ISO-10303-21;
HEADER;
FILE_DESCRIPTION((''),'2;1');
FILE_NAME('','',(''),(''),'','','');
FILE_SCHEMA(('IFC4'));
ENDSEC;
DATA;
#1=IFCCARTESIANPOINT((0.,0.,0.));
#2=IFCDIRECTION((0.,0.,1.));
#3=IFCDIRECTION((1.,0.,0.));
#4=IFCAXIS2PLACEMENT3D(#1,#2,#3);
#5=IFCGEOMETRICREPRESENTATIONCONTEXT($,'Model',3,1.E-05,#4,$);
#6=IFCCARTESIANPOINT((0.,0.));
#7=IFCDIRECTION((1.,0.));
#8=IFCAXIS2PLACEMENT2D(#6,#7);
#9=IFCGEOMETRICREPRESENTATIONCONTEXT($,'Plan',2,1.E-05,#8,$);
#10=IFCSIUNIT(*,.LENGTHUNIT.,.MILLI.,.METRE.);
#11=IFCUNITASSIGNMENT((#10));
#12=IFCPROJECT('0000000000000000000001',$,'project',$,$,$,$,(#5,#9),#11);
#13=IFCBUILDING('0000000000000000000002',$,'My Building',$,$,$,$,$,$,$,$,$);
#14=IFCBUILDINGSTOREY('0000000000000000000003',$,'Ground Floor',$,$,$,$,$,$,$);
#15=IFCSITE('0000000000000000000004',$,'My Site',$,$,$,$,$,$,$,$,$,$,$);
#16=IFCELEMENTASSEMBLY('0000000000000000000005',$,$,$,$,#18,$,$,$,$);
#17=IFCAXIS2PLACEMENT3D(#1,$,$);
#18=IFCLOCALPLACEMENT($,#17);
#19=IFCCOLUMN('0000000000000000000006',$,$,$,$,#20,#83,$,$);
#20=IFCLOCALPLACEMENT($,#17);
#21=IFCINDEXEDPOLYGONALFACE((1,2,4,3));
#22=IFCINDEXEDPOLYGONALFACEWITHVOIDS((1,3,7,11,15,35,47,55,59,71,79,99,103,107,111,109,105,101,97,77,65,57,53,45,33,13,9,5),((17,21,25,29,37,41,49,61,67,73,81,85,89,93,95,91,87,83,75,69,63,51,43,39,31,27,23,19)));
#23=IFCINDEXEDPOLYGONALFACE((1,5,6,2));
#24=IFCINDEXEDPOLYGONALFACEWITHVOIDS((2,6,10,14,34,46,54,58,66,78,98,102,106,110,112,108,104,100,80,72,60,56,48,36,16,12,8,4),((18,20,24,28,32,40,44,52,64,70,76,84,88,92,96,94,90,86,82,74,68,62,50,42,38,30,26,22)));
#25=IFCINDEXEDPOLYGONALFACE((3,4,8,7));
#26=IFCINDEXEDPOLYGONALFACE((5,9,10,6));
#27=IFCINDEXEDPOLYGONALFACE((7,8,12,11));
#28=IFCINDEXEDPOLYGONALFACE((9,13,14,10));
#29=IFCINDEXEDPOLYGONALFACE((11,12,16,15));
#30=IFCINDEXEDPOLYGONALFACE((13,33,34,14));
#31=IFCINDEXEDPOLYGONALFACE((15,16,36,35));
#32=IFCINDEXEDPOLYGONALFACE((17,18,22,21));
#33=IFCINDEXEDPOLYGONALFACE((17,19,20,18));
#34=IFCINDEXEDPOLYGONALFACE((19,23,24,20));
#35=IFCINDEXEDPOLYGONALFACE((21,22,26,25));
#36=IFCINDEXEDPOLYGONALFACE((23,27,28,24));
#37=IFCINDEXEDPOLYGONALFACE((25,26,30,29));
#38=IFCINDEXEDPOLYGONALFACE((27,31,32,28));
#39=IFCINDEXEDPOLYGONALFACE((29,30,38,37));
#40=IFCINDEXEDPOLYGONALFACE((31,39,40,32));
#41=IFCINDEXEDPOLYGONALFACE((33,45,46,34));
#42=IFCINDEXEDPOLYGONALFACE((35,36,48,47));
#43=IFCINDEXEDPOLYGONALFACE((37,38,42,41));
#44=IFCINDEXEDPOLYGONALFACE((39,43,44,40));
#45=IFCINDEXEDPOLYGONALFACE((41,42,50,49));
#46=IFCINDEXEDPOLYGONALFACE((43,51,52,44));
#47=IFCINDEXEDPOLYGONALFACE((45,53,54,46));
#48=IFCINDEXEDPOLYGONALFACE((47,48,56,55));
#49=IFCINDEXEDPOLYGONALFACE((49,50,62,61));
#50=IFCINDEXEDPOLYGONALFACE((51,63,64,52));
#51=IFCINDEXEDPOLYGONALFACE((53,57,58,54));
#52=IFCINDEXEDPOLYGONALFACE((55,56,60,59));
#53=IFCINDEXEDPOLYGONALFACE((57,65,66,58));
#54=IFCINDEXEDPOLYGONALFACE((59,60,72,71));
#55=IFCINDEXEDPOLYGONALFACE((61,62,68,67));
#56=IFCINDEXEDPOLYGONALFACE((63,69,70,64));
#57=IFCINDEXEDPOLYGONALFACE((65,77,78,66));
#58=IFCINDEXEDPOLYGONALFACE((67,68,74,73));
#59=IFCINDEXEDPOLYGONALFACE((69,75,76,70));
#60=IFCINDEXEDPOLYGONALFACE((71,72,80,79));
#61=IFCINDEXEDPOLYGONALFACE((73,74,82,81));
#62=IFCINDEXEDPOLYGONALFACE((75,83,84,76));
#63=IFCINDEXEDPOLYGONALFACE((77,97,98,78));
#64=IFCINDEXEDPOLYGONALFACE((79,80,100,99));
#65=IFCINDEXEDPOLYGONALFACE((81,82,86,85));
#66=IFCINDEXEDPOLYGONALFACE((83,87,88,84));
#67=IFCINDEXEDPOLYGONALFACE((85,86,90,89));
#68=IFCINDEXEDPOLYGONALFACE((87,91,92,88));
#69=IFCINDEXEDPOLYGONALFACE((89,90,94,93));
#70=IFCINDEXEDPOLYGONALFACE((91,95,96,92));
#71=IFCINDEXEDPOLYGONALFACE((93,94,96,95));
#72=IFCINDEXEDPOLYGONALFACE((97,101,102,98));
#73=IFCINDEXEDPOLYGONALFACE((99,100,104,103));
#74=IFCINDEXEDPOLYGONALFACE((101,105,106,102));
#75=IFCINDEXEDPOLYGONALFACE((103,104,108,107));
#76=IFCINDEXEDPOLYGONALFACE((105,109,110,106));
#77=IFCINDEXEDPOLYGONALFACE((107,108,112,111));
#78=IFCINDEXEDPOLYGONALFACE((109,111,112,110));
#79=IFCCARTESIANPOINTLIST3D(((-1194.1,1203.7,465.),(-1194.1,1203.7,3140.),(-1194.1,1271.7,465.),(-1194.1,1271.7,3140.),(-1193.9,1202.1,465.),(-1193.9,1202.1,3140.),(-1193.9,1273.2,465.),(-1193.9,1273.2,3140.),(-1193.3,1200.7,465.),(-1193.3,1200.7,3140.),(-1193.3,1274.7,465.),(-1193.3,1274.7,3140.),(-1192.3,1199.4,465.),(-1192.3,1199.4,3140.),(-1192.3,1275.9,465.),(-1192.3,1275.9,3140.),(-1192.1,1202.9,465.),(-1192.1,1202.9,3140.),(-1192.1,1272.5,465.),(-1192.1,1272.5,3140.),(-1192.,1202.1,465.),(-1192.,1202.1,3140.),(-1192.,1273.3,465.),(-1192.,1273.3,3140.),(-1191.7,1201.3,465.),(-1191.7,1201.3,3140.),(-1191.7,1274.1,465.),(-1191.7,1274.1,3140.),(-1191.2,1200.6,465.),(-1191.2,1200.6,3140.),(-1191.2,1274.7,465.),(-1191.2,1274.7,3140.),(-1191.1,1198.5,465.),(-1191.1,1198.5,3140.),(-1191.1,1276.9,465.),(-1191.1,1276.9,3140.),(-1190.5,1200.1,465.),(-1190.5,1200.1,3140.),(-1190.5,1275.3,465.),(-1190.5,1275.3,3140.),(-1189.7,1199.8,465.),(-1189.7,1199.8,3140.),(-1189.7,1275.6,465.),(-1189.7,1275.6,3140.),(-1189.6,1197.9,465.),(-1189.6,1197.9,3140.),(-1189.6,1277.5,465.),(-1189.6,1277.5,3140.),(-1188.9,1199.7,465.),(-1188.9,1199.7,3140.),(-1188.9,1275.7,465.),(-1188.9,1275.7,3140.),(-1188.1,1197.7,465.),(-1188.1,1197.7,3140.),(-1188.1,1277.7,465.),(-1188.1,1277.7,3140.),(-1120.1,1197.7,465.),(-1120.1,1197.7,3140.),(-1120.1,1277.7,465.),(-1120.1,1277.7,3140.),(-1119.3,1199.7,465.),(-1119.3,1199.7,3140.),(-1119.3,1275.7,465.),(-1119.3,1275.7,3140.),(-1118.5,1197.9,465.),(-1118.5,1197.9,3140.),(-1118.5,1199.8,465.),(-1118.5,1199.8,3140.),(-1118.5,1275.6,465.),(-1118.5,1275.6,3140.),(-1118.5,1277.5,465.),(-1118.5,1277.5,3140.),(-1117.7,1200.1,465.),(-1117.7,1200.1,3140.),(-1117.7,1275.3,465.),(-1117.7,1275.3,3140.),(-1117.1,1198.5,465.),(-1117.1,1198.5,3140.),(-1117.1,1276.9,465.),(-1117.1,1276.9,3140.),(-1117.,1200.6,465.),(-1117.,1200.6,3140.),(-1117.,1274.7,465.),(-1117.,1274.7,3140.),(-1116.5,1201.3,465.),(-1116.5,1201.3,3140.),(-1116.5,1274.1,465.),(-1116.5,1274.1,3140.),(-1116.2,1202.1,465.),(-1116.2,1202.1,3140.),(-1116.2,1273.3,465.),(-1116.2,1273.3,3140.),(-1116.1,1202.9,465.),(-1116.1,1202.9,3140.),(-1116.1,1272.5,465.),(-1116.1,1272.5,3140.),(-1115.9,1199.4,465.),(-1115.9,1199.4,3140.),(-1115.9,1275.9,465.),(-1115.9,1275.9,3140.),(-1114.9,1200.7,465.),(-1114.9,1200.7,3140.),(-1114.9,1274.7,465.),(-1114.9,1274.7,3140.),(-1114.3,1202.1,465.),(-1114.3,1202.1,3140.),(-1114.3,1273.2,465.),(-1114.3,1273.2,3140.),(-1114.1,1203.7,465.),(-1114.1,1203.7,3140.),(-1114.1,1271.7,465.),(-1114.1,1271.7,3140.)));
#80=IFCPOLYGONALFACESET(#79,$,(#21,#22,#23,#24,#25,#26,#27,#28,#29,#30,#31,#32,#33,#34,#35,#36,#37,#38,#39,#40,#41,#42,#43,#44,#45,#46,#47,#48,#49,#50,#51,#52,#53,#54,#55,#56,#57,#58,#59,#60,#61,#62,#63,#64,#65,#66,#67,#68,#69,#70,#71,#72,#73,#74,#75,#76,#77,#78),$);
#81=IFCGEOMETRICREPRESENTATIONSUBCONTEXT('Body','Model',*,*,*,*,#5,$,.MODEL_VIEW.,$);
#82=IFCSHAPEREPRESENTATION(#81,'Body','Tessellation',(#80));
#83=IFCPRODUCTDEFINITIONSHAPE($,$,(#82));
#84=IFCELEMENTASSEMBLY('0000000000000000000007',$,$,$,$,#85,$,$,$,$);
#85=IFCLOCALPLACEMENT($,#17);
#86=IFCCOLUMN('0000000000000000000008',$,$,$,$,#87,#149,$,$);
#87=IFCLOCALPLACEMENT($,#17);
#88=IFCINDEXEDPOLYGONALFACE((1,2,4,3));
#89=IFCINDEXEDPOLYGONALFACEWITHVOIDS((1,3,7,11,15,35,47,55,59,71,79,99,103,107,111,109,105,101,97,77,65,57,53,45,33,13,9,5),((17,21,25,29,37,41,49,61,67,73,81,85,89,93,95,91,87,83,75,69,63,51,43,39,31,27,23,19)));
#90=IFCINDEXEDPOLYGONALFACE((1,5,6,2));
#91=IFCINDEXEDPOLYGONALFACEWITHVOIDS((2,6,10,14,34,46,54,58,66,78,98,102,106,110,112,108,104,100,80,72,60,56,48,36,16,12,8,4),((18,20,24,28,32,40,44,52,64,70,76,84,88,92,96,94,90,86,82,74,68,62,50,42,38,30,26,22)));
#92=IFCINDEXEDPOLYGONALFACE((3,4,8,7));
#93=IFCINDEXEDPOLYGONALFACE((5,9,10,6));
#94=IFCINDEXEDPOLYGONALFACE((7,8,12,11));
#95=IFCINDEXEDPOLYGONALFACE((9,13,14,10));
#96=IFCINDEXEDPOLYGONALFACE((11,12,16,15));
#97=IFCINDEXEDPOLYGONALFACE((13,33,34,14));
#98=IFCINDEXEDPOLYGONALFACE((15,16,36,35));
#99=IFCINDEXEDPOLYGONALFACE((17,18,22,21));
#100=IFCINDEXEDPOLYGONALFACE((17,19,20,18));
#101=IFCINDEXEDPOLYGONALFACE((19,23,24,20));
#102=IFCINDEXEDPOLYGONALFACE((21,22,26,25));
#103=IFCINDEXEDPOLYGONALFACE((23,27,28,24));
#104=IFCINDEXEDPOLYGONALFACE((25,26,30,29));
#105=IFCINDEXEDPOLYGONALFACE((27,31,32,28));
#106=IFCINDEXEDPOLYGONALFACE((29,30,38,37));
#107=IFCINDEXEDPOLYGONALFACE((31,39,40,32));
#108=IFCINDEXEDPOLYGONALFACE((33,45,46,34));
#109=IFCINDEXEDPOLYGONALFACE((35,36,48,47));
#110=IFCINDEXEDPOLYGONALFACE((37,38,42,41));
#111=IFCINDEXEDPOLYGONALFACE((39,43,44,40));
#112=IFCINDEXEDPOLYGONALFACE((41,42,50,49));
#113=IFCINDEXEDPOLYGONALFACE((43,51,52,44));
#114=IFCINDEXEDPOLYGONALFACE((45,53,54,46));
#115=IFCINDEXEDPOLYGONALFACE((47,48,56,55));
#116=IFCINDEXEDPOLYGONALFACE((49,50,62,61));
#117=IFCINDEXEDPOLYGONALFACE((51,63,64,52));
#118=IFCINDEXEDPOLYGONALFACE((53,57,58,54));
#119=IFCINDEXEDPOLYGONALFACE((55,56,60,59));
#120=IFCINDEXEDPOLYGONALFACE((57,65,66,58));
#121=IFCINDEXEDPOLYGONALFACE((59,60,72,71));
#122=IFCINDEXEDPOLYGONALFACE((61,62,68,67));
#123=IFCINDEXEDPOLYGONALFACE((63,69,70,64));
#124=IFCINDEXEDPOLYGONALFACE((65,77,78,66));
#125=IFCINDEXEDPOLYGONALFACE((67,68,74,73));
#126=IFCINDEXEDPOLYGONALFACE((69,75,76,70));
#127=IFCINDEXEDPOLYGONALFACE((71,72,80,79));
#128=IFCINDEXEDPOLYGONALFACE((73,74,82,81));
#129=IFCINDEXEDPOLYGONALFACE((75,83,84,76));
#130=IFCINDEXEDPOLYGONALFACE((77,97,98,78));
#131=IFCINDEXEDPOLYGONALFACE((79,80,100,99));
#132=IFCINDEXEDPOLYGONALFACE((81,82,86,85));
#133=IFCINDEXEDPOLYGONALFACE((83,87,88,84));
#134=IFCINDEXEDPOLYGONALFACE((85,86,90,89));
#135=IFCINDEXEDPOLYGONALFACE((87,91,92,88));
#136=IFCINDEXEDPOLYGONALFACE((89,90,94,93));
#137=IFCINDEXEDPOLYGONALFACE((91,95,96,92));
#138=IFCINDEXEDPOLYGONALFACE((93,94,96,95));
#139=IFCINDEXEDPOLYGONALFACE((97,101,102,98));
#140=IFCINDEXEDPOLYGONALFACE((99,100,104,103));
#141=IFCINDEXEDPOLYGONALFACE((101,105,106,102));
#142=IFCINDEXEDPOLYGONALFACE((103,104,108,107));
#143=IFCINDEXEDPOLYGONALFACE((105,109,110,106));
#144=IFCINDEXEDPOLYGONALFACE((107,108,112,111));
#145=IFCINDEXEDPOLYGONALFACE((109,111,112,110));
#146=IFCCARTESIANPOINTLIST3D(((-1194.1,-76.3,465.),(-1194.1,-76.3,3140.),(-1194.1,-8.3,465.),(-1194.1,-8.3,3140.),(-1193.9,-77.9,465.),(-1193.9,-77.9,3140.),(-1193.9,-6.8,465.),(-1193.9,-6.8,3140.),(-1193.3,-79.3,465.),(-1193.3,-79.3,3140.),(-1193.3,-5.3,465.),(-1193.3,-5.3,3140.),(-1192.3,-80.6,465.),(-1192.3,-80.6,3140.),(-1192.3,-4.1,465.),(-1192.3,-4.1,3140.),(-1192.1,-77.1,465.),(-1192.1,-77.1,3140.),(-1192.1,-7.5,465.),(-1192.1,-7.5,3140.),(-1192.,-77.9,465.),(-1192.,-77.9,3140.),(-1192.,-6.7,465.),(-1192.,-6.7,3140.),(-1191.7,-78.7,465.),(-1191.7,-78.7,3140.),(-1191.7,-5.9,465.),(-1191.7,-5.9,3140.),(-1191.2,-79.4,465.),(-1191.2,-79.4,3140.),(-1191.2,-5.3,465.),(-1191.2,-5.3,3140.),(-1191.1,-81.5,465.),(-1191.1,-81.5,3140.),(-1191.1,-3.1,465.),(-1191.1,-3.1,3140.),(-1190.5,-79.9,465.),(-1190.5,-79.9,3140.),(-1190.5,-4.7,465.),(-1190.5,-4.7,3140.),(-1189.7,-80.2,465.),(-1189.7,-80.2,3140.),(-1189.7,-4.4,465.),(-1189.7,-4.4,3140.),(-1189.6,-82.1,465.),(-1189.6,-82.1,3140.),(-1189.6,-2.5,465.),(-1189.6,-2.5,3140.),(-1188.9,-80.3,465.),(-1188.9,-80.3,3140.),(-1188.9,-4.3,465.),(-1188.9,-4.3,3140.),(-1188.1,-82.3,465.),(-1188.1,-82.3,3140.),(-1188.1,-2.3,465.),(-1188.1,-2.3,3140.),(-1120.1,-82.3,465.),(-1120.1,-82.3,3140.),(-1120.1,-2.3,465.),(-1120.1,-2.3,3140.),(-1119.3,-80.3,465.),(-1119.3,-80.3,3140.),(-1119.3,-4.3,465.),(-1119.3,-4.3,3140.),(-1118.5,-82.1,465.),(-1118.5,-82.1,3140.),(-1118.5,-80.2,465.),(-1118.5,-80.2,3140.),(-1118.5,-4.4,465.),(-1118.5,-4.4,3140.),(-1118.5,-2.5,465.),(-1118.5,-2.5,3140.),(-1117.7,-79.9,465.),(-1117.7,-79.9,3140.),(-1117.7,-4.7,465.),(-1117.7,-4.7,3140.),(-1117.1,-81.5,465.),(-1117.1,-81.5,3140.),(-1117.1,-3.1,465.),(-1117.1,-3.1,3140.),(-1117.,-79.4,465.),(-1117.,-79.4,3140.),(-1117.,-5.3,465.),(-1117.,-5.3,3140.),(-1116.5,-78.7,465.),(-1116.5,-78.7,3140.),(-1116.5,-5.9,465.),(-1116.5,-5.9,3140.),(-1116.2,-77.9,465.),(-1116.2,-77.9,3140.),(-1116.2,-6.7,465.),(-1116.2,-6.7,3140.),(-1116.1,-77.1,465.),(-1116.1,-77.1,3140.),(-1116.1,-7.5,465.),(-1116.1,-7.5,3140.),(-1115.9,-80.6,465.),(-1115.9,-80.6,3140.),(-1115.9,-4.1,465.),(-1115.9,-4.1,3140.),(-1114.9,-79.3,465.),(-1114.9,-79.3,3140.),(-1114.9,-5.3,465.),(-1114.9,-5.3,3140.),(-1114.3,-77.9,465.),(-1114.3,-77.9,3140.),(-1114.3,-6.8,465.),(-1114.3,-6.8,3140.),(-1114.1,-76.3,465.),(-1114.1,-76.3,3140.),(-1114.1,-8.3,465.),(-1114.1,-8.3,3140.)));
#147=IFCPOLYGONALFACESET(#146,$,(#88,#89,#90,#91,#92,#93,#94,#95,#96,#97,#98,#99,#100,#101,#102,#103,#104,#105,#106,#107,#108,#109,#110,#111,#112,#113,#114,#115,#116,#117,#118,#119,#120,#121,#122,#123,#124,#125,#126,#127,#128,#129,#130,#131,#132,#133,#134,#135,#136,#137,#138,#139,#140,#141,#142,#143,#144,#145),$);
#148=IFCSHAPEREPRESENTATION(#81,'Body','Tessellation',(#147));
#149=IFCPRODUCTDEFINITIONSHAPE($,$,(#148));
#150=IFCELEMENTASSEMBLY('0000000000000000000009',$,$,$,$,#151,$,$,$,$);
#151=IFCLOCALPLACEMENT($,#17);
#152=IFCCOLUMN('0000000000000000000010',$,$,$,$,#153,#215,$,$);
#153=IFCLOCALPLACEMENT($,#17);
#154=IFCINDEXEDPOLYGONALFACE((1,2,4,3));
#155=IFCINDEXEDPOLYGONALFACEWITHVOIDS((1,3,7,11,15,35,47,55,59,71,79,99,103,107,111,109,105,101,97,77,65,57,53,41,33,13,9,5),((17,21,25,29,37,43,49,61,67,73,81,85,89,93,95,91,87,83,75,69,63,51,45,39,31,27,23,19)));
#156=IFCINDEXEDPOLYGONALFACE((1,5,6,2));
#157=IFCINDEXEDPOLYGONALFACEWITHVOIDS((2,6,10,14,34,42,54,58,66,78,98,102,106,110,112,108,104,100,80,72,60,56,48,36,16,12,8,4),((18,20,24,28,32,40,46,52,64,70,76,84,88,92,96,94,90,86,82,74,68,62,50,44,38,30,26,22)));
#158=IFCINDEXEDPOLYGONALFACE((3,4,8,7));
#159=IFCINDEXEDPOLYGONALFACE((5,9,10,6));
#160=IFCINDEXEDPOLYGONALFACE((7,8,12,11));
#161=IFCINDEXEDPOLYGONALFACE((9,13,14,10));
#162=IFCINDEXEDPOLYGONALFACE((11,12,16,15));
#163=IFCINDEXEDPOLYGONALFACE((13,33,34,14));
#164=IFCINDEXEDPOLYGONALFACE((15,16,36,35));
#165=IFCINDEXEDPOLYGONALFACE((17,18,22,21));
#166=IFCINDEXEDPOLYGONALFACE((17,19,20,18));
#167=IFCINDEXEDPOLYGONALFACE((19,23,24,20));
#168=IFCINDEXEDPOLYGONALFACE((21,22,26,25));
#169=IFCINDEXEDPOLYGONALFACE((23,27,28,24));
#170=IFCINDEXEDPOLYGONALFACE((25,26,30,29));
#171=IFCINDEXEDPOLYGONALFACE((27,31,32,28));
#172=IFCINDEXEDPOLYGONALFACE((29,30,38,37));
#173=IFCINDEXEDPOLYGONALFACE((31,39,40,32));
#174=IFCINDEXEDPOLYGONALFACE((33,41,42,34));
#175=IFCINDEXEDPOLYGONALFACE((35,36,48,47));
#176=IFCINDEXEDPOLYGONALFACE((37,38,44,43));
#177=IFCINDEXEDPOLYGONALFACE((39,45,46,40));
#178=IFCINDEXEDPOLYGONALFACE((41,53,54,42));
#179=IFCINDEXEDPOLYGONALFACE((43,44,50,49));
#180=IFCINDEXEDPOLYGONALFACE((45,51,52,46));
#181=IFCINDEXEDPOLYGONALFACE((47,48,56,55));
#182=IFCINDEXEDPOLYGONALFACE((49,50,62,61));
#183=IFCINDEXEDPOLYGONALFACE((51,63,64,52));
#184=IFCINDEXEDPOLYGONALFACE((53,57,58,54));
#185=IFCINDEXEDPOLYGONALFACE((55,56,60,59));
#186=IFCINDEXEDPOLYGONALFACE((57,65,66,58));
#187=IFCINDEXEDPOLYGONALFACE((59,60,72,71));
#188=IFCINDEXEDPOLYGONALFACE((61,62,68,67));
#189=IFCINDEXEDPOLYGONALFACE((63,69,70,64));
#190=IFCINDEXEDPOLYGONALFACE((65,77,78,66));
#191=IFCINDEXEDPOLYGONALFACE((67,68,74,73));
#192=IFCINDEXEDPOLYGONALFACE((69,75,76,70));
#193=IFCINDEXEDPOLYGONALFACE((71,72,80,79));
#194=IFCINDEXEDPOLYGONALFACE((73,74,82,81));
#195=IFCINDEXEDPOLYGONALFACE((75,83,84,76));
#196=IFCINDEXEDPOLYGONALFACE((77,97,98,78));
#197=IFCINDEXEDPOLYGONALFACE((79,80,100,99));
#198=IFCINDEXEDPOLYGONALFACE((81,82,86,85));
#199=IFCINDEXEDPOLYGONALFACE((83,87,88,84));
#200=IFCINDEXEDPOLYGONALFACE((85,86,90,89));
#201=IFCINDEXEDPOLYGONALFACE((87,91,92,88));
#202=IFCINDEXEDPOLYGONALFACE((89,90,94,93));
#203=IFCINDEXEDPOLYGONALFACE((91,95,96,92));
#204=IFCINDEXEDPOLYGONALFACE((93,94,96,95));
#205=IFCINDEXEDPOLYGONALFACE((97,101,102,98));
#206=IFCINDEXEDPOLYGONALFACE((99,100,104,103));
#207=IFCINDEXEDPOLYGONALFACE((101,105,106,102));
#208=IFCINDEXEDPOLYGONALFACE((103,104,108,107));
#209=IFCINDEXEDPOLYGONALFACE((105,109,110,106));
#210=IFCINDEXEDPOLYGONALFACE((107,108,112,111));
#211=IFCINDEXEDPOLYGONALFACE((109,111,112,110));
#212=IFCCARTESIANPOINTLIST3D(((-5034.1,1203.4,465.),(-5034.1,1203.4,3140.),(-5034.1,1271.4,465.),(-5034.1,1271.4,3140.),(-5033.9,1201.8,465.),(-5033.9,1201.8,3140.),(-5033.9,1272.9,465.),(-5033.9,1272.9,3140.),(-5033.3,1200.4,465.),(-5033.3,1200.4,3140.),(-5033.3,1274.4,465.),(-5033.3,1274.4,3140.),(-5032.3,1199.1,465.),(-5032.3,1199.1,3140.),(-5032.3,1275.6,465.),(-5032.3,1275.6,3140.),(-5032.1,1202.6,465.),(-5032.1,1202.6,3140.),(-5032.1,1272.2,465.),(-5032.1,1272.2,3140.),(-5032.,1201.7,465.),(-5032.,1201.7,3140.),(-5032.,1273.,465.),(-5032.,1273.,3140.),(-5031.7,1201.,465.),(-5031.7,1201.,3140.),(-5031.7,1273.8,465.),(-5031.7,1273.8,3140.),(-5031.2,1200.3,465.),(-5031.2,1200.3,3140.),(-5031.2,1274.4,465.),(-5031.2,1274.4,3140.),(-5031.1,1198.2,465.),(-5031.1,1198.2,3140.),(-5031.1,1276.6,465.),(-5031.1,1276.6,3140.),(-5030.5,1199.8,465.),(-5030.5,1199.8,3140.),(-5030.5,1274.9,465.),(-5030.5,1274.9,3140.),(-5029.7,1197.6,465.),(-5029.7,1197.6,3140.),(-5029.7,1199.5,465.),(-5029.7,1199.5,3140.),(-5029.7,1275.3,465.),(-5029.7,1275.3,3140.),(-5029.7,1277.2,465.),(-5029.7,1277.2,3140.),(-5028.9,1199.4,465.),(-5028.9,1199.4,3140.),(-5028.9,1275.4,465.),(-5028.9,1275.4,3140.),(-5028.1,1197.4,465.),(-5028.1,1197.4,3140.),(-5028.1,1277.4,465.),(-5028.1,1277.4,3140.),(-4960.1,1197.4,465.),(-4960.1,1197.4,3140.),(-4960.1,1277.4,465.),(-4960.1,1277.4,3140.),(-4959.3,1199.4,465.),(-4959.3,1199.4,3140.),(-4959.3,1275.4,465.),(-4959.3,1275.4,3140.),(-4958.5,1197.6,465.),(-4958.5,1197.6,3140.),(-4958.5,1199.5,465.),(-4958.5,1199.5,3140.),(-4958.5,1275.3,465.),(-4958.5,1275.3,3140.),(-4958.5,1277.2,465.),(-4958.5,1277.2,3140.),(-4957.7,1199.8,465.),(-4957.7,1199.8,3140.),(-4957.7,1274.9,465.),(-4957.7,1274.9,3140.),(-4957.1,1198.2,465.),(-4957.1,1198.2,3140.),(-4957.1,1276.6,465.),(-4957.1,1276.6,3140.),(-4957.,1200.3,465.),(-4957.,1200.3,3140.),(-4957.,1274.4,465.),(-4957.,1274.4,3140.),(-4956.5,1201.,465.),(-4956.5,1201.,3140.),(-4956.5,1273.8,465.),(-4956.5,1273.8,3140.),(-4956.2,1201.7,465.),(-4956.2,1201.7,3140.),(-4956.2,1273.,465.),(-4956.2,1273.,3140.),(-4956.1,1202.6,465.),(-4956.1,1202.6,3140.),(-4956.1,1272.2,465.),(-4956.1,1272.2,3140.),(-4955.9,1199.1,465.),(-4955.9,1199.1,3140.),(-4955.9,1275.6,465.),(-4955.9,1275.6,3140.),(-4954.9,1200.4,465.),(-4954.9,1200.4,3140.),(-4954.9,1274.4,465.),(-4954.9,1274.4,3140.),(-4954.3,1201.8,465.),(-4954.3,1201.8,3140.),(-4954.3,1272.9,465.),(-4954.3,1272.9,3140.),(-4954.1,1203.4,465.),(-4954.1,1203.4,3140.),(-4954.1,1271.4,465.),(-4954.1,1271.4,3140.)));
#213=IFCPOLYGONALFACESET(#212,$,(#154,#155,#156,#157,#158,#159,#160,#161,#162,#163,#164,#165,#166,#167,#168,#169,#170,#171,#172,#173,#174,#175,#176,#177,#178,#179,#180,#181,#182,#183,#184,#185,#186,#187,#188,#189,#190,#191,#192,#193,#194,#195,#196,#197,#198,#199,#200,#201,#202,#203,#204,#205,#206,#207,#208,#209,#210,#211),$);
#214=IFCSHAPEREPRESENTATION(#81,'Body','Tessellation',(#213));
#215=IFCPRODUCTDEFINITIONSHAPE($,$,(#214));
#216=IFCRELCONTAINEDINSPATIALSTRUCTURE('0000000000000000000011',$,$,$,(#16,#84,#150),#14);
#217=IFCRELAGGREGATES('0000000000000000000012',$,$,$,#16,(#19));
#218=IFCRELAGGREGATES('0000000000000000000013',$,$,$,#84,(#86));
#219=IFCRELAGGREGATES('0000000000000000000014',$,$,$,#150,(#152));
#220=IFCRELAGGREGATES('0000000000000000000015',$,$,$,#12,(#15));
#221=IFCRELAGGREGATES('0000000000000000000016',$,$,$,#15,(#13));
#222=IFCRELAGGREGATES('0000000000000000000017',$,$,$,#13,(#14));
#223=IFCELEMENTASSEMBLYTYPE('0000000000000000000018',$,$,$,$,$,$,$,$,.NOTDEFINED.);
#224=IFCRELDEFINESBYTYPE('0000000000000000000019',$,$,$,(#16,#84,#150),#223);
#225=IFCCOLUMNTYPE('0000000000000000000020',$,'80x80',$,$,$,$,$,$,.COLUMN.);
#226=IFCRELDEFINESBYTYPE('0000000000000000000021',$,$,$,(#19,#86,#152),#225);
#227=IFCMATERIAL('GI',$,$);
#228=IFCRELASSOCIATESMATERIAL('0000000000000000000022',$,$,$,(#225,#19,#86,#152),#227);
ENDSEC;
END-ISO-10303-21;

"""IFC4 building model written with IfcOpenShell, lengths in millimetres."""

from ifc_helpers import new_model, si_unit, frame, origin_with_axes, origin_2d_with_axis, place, context, subcontext, project, spatial, hollow_rectangle, extrude, material, material_profile, profile_set, profile_usage, type_object, element, aggregate, save


model = new_model("IFC4")

# Units and contexts
model_context = context("Model", 3, precision=1e-05, world=origin_with_axes())
plan_context = context("Plan", 2, precision=1e-05, world=origin_2d_with_axis())
body_context = subcontext(model_context, "Body", "Model", "MODEL_VIEW")
ifc_project = project(units=[si_unit("LENGTHUNIT", "METRE", prefix="MILLI")], contexts=[model_context, plan_context])

# Site, building, storey
site = spatial("IfcSite", under=ifc_project, Name="My Site")
building = spatial("IfcBuilding", under=site, Name="My Building")
storey = spatial("IfcBuildingStorey", under=building, Name="Ground Floor")

# Element assemblies, columns
element_assembly_type_1 = type_object("IfcElementAssemblyType", PredefinedType="NOTDEFINED")
assembly_1_placement = place(None, frame((-1154.1, 1237.7, 465.0), z_axis=(0.0, 0.0, 1.0), x_axis=(1.0, 0.0, 0.0)))
assembly_1 = element("IfcElementAssembly", 1, at=assembly_1_placement, inside=storey, type_object=element_assembly_type_1)
ifc_material_1 = material(Name="GI")
ifc_material_profile_1 = material_profile(ifc_material_1, hollow_rectangle(XDim=80.0, YDim=80.0, WallThickness=2.0, InnerFilletRadius=3.2, OuterFilletRadius=6.0))
ifc_profile_set_1 = profile_set([ifc_material_profile_1], Name="80x80 GI Rectangular Hollow")
ifc_profile_usage_1 = profile_usage(ifc_profile_set_1)
column_type = type_object("IfcColumnType", Name="80x80", PredefinedType="COLUMN", material=ifc_profile_set_1)
column_1_placement = place(assembly_1_placement, origin_with_axes())
column_1 = element("IfcColumn", 2, at=column_1_placement, type_object=column_type, material=ifc_profile_usage_1, context=body_context, shape_type="SweptSolid", body=[
    extrude(hollow_rectangle(XDim=80.0, YDim=80.0, WallThickness=2.0, InnerFilletRadius=3.2, OuterFilletRadius=6.0), origin_with_axes(), (0.0, 0.0, 1.0), 2675.0),
])
aggregate(assembly_1, [column_1])
assembly_2_placement = place(None, frame((-1154.1, -42.3, 465.0), z_axis=(0.0, 0.0, 1.0), x_axis=(1.0, 0.0, 0.0)))
assembly_2 = element("IfcElementAssembly", 3, at=assembly_2_placement, inside=storey, type_object=element_assembly_type_1)
ifc_profile_usage_2 = profile_usage(ifc_profile_set_1)
column_2_placement = place(assembly_2_placement, origin_with_axes())
column_2 = element("IfcColumn", 4, at=column_2_placement, type_object=column_type, material=ifc_profile_usage_2, context=body_context, shape_type="SweptSolid", body=[
    extrude(hollow_rectangle(XDim=80.0, YDim=80.0, WallThickness=2.0, InnerFilletRadius=3.2, OuterFilletRadius=6.0), origin_with_axes(), (0.0, 0.0, 1.0), 2675.0),
])
aggregate(assembly_2, [column_2])
assembly_3_placement = place(None, frame((-4994.1, 1237.4, 465.0), z_axis=(0.0, 0.0, 1.0), x_axis=(1.0, 0.0, 0.0)))
assembly_3 = element("IfcElementAssembly", 5, at=assembly_3_placement, inside=storey, type_object=element_assembly_type_1)
ifc_profile_usage_3 = profile_usage(ifc_profile_set_1)
column_3_placement = place(assembly_3_placement, origin_with_axes())
column_3 = element("IfcColumn", 6, at=column_3_placement, type_object=column_type, material=ifc_profile_usage_3, context=body_context, shape_type="SweptSolid", body=[
    extrude(hollow_rectangle(XDim=80.0, YDim=80.0, WallThickness=2.0, InnerFilletRadius=3.2, OuterFilletRadius=6.0), origin_with_axes(), (0.0, 0.0, 1.0), 2675.0),
])
aggregate(assembly_3, [column_3])

save(model, "model.ifc")
